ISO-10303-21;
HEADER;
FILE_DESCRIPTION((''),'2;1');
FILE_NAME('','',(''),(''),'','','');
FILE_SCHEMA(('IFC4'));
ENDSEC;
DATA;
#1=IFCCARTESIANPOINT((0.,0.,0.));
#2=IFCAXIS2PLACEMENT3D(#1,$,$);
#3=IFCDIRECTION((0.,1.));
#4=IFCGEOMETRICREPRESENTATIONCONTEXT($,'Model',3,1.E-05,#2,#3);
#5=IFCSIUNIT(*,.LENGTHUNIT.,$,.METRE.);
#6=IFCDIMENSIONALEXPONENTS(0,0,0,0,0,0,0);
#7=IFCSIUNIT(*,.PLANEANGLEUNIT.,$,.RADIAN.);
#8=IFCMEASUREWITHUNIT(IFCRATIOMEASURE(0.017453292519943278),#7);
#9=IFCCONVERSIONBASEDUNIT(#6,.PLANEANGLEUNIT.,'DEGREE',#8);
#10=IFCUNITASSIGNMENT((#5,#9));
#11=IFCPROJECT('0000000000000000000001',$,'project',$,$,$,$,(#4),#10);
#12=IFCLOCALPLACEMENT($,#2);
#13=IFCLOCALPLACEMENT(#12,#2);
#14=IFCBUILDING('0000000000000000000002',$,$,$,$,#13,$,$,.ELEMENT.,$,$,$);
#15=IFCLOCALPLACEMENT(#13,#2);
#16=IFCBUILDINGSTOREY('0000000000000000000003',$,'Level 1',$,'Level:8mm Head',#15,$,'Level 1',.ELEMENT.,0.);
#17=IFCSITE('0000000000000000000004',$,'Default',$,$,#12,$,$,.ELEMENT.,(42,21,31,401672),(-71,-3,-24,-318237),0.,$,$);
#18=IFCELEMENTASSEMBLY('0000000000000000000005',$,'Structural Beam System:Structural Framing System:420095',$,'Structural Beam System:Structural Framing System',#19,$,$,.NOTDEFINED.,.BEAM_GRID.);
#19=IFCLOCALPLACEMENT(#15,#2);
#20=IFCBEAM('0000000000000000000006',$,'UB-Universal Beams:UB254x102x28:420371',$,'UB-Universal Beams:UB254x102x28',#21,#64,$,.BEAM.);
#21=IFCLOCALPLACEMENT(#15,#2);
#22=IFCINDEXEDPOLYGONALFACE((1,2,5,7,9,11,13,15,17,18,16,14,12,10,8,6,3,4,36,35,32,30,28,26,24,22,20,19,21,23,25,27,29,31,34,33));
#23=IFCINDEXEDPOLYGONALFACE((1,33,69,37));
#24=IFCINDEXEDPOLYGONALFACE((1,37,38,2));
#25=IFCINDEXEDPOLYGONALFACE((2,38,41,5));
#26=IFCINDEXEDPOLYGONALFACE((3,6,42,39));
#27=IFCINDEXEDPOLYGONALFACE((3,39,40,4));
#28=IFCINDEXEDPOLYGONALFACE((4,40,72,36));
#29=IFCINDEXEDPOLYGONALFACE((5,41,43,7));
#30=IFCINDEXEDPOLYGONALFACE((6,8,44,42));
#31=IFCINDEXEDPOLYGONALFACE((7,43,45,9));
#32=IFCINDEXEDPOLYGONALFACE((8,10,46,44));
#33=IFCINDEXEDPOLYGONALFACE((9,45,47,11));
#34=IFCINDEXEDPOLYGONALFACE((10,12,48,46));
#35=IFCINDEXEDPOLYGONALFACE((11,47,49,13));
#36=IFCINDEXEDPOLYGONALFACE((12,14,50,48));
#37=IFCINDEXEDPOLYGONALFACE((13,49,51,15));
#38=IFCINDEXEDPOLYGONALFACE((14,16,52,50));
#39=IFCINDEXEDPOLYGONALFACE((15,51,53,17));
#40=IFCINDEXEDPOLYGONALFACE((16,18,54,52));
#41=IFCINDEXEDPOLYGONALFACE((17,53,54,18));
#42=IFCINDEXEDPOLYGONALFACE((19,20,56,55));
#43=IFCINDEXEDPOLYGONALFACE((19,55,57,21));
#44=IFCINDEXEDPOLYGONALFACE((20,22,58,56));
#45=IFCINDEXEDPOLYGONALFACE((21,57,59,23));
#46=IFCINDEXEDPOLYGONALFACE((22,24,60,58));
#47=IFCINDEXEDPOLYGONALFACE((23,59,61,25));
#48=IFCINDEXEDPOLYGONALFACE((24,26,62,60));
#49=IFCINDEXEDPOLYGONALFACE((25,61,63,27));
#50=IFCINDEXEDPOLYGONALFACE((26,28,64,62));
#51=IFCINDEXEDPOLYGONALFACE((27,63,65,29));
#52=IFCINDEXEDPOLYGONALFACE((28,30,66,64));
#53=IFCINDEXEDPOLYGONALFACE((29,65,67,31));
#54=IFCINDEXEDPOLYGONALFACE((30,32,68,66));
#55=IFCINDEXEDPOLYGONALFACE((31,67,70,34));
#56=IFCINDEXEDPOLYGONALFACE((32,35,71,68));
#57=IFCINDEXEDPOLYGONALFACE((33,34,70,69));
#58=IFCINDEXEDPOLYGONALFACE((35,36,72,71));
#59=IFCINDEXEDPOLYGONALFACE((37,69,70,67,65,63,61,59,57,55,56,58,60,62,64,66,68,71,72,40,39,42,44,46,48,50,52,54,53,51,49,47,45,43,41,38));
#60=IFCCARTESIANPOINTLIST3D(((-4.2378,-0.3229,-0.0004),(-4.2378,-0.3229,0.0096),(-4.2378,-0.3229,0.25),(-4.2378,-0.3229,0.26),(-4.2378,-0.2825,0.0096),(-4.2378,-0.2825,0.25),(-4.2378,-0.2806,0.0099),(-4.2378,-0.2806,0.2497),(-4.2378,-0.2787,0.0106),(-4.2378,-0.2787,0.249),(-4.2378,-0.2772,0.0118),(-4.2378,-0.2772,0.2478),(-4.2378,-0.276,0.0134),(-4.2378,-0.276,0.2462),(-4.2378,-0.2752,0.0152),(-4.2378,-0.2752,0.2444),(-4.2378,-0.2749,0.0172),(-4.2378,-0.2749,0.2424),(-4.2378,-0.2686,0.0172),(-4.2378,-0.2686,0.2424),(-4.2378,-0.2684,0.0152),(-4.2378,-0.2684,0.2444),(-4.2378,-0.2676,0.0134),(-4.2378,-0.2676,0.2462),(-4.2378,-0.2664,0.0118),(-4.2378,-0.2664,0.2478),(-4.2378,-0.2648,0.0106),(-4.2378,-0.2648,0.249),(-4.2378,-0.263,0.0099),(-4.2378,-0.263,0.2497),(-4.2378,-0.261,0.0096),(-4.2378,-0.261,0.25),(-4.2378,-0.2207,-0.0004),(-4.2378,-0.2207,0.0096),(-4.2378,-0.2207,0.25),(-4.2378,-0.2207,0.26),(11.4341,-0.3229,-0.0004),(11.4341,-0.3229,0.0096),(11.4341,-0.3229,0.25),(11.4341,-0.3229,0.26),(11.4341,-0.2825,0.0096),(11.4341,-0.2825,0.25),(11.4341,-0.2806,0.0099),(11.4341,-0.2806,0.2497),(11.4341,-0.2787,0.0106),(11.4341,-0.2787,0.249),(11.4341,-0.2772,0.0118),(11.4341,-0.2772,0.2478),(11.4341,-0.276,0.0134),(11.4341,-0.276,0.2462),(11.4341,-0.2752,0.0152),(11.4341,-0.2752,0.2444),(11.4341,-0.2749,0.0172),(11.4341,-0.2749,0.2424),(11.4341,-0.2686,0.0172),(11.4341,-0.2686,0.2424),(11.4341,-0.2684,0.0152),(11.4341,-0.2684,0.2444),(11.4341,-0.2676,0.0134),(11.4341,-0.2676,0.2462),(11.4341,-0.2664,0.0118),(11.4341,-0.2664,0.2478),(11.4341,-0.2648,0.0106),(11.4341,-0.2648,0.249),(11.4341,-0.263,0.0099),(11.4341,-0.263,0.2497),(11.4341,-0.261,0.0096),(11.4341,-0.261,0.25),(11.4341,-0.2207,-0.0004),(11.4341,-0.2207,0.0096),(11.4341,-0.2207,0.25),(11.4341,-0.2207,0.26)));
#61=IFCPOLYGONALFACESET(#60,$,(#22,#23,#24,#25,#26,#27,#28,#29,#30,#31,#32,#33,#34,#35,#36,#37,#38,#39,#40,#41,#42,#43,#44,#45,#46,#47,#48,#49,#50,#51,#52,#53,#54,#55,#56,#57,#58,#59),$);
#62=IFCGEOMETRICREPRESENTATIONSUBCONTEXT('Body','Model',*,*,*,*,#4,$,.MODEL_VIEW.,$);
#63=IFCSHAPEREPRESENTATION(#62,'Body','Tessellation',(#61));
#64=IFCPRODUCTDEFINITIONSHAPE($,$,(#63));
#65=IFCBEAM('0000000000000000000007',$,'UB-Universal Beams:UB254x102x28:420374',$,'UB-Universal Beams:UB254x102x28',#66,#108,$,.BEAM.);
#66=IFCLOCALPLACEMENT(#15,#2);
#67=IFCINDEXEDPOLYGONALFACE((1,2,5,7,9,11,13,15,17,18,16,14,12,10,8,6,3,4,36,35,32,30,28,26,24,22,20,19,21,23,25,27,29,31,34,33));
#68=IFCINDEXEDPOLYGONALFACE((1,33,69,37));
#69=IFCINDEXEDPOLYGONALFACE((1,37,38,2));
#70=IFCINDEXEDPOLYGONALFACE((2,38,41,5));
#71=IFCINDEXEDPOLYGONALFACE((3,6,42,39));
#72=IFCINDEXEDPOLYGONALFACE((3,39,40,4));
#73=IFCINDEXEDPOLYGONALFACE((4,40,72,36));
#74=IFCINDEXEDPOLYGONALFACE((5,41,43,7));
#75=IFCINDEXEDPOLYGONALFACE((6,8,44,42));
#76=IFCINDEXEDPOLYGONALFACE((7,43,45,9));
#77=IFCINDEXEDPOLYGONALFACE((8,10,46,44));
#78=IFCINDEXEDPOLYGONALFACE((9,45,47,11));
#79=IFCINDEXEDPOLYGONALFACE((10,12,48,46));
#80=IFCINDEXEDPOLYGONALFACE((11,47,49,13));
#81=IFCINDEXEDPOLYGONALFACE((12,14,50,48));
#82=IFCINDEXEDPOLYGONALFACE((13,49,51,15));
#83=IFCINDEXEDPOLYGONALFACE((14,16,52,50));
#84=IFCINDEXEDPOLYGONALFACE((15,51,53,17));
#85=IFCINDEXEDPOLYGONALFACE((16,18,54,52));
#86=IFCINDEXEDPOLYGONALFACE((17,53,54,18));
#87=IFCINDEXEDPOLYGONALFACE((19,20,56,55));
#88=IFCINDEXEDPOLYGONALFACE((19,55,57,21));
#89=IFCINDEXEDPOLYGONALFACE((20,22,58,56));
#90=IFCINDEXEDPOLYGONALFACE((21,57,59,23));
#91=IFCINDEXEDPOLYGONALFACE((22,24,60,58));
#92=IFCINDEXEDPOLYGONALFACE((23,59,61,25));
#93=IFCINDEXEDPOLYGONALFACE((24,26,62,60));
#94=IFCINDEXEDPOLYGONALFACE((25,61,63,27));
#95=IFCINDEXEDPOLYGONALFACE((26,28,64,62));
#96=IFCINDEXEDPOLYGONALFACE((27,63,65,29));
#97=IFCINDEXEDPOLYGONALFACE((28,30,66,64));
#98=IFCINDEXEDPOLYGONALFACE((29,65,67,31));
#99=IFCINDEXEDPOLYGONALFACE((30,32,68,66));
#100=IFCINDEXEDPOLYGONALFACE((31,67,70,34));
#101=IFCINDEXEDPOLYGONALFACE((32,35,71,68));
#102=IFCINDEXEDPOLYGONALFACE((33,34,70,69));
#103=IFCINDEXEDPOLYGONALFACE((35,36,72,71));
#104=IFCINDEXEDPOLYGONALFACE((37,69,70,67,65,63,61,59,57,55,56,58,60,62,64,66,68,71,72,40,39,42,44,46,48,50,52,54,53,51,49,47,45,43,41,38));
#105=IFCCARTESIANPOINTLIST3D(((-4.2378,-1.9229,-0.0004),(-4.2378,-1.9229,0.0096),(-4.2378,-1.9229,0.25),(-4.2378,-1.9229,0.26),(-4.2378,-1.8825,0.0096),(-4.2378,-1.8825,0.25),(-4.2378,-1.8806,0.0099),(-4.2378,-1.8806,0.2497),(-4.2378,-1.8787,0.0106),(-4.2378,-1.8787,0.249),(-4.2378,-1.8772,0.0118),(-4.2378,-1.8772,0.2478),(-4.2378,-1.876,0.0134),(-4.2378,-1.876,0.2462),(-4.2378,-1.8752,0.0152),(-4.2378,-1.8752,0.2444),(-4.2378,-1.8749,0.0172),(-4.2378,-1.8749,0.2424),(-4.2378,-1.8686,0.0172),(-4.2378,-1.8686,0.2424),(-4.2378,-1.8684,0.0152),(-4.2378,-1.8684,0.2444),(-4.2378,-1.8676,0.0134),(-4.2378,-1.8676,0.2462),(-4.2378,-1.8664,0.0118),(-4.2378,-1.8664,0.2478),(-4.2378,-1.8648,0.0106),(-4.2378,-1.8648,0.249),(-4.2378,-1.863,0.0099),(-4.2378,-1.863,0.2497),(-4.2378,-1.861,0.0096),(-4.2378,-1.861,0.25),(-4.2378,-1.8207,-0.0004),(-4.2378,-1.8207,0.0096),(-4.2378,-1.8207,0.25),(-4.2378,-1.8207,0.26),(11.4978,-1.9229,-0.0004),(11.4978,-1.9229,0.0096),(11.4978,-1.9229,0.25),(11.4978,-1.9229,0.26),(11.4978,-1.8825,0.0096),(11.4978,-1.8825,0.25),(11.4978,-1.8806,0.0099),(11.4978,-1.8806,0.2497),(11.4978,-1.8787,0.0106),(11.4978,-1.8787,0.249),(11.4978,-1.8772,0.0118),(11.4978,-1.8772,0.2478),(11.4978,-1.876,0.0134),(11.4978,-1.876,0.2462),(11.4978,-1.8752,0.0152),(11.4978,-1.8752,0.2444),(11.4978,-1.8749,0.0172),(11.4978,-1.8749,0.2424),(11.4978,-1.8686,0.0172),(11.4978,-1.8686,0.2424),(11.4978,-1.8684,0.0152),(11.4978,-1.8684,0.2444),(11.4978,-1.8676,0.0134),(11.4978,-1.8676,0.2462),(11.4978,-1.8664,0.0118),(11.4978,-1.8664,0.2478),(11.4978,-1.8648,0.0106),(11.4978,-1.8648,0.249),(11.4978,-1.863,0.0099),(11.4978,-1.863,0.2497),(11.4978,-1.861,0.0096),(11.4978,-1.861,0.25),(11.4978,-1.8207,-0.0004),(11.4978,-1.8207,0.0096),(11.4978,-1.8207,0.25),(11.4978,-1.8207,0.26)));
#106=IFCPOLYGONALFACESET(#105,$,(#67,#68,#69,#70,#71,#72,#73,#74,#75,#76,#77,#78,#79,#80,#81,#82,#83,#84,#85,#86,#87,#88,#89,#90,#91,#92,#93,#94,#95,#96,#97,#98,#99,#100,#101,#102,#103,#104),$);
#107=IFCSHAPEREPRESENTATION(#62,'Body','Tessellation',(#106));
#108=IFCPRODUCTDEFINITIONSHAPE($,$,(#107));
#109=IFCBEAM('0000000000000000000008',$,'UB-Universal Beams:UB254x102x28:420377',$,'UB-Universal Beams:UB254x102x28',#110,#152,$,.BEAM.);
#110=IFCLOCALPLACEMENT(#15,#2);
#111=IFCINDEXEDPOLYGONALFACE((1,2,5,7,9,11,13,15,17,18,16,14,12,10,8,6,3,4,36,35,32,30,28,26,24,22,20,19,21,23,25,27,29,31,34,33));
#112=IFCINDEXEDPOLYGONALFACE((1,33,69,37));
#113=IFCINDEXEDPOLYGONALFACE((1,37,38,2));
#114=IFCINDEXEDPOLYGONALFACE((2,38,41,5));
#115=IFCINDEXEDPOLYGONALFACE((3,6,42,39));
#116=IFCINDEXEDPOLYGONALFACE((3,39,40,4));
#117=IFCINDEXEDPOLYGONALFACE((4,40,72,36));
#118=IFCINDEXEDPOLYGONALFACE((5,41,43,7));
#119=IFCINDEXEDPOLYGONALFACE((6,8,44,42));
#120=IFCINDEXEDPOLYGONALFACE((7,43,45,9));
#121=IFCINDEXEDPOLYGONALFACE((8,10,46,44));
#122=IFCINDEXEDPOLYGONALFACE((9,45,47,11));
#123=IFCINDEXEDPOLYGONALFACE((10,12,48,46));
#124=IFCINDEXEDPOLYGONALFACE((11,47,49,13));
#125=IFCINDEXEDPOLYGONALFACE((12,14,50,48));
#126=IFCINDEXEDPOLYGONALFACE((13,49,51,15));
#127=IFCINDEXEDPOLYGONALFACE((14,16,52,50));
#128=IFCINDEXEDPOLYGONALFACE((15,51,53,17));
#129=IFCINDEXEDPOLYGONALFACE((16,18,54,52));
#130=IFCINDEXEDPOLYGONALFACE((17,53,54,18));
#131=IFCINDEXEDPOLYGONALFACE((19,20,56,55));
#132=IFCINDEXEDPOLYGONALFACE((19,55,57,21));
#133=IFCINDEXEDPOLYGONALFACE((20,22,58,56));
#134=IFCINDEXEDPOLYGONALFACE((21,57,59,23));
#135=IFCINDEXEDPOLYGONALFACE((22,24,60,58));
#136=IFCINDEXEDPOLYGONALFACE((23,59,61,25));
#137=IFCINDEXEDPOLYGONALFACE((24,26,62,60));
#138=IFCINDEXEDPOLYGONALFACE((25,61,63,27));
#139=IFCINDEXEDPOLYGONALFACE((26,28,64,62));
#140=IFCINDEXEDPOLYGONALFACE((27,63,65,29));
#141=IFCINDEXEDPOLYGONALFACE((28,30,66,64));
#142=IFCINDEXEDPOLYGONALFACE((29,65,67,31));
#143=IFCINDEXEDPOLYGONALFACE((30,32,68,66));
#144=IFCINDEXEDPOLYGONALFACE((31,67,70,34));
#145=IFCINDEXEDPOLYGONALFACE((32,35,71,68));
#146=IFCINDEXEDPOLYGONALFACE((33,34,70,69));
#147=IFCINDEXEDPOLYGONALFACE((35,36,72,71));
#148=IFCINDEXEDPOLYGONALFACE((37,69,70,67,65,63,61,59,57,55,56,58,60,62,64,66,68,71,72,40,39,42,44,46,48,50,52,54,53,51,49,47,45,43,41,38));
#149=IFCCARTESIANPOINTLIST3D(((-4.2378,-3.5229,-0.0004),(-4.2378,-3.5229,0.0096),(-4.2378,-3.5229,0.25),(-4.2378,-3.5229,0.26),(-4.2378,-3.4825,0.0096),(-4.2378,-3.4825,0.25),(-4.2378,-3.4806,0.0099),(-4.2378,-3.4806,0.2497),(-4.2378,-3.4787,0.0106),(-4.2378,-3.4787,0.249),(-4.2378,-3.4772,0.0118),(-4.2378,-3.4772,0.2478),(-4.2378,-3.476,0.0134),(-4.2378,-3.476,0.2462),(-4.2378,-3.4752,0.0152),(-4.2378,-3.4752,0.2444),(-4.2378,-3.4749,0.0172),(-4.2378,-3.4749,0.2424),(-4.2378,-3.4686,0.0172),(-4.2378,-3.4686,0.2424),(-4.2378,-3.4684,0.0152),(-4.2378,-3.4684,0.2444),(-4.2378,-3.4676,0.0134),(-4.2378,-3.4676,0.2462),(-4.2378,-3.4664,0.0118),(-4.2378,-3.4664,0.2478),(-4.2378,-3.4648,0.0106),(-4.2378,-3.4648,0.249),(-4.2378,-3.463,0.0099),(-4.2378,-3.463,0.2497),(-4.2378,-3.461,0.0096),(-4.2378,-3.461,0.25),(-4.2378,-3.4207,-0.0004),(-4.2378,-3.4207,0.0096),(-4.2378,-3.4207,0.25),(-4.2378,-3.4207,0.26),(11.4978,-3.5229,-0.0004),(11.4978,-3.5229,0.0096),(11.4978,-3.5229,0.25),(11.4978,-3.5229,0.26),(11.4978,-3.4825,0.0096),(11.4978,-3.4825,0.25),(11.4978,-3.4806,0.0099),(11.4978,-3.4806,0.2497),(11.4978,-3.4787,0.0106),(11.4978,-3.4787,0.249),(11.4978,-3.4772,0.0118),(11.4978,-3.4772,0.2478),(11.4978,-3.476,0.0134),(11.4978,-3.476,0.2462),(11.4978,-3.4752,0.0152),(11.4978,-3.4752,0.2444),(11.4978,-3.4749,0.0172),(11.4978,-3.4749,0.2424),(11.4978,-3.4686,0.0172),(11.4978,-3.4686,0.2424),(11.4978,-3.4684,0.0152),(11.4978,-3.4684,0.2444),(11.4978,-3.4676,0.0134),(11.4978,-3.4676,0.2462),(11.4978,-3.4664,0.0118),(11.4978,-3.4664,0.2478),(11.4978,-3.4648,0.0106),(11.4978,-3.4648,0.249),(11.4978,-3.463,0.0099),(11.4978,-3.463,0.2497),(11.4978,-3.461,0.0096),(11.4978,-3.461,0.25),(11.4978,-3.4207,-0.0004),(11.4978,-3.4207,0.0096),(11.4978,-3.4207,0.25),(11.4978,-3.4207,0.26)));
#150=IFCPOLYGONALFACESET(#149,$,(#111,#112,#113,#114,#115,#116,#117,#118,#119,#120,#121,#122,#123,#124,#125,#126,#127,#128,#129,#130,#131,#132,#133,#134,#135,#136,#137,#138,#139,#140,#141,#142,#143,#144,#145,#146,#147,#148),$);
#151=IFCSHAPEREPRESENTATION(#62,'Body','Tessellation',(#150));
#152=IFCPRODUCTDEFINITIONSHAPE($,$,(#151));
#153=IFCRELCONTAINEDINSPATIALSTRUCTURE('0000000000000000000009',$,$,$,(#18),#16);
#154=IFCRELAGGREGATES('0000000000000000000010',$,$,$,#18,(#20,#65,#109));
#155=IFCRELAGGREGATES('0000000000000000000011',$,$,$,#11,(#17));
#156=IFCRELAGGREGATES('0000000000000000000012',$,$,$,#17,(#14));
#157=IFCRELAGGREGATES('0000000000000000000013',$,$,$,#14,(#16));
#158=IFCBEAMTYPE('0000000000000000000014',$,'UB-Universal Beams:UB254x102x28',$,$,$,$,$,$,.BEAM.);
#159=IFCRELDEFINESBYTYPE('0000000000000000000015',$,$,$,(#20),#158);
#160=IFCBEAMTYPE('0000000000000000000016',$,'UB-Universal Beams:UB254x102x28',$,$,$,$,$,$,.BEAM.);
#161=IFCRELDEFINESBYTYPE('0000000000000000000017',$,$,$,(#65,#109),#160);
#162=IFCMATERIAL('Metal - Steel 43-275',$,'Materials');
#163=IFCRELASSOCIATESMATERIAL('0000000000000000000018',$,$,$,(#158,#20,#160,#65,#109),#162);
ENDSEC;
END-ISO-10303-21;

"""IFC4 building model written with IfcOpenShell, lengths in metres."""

from ifc_helpers import new_model, entity, si_unit, converted_unit, direction, frame, origin, place, context, subcontext, project, spatial, line, arc, indexed_curve, outline, extrude, source, transform, mapped, material, type_object, type_shapes, element, aggregate, save


model = new_model("IFC4")

# Units and contexts
model_context = context("Model", 3, precision=1e-05, world=origin(), true_north=direction((0.0, 1.0)))
body_context = subcontext(model_context, "Body", "Model", "MODEL_VIEW")
ifc_project = project(units=[si_unit("LENGTHUNIT", "METRE"), converted_unit("PLANEANGLEUNIT", "DEGREE", entity("IfcRatioMeasure", 0.017453292519943278), si_unit("PLANEANGLEUNIT", "RADIAN"), dimensions=[0, 0, 0, 0, 0, 0, 0])], contexts=[model_context])

# Site, building, storey
site_placement = place(None, origin())
site = spatial("IfcSite", under=ifc_project, at=site_placement, Name="Default", CompositionType="ELEMENT", RefLatitude=(42, 21, 31, 401672), RefLongitude=(-71, -3, -24, -318237), RefElevation=0.0)
building_placement = place(site_placement, origin())
building = spatial("IfcBuilding", under=site, at=building_placement, CompositionType="ELEMENT")
storey_placement = place(building_placement, origin())
storey = spatial("IfcBuildingStorey", under=building, at=storey_placement, Name="Level 1", ObjectType="Level:8mm Head", LongName="Level 1", CompositionType="ELEMENT", Elevation=0.0)

# Shared definitions
ifc_material_1 = material(Name="Metal - Steel 43-275", Category="Materials")

# Element assembly, beams
assembly_placement = place(storey_placement, origin())
assembly = element("IfcElementAssembly", 1, at=assembly_placement, inside=storey, Name="Structural Beam System:Structural Framing System:420095", ObjectType="Structural Beam System:Structural Framing System", AssemblyPlace="NOTDEFINED", PredefinedType="BEAM_GRID")
beam_type_1 = type_object("IfcBeamType", Name="UB-Universal Beams:UB254x102x28", PredefinedType="BEAM", material=ifc_material_1)
shared_shape_1 = source(origin(), body_context, "Body", "SweptSolid", [
    extrude(outline(indexed_curve([(-0.1302, -0.0511), (-0.1202, -0.0511), (-0.1202, -0.0107), (-0.118, -0.0054), (-0.1126, -0.0031), (0.1126, -0.0031), (0.118, -0.0054), (0.1202, -0.0107), (0.1202, -0.0511), (0.1302, -0.0511), (0.1302, 0.0511), (0.1202, 0.0511), (0.1202, 0.0108), (0.118, 0.0054), (0.1126, 0.0032), (-0.1126, 0.0032), (-0.118, 0.0054), (-0.1202, 0.0108), (-0.1202, 0.0511), (-0.1302, 0.0511)], segments=[line(1, 2, 3), arc(3, 4, 5), line(5, 6), arc(6, 7, 8), line(8, 9, 10, 11, 12, 13), arc(13, 14, 15), line(15, 16), arc(16, 17, 18), line(18, 19, 20, 1)], self_intersect=False)), frame((-7.8818, 0.0, 0.0), z_axis=(1.0, 0.0, 0.0), x_axis=(0.0, 0.0, -1.0)), (0.0, 0.0, 1.0), 15.6719),
])
type_shapes(beam_type_1, [shared_shape_1])
beam_1_placement = place(assembly_placement, frame((3.644, -0.2718, 0.1298)))
beam_1 = element("IfcBeam", 2, at=beam_1_placement, type_object=beam_type_1, material=ifc_material_1, Name="UB-Universal Beams:UB254x102x28:420371", ObjectType="UB-Universal Beams:UB254x102x28", PredefinedType="BEAM", context=body_context, shape_type="MappedRepresentation", body=[
    mapped(shared_shape_1, transform((0.0, 0.0, 0.0), scale=1.0)),
])
beam_type_2 = type_object("IfcBeamType", Name="UB-Universal Beams:UB254x102x28", PredefinedType="BEAM", material=ifc_material_1)
shared_shape_2 = source(origin(), body_context, "Body", "SweptSolid", [
    extrude(outline(indexed_curve([(-0.1302, -0.0511), (-0.1202, -0.0511), (-0.1202, -0.0107), (-0.118, -0.0054), (-0.1126, -0.0031), (0.1126, -0.0031), (0.118, -0.0054), (0.1202, -0.0107), (0.1202, -0.0511), (0.1302, -0.0511), (0.1302, 0.0511), (0.1202, 0.0511), (0.1202, 0.0108), (0.118, 0.0054), (0.1126, 0.0032), (-0.1126, 0.0032), (-0.118, 0.0054), (-0.1202, 0.0108), (-0.1202, 0.0511), (-0.1302, 0.0511)], segments=[line(1, 2, 3), arc(3, 4, 5), line(5, 6), arc(6, 7, 8), line(8, 9, 10, 11, 12, 13), arc(13, 14, 15), line(15, 16), arc(16, 17, 18), line(18, 19, 20, 1)], self_intersect=False)), frame((-7.8373, 0.0, 0.0), z_axis=(1.0, 0.0, 0.0), x_axis=(0.0, 0.0, -1.0)), (0.0, 0.0, 1.0), 15.7356),
])
type_shapes(beam_type_2, [shared_shape_2])
beam_2_placement = place(assembly_placement, frame((3.5995, -1.8718, 0.1298)))
beam_2 = element("IfcBeam", 3, at=beam_2_placement, type_object=beam_type_2, material=ifc_material_1, Name="UB-Universal Beams:UB254x102x28:420374", ObjectType="UB-Universal Beams:UB254x102x28", PredefinedType="BEAM", context=body_context, shape_type="MappedRepresentation", body=[
    mapped(shared_shape_2, transform((0.0, 0.0, 0.0), scale=1.0)),
])
beam_3_placement = place(assembly_placement, frame((3.5995, -3.4718, 0.1298)))
beam_3 = element("IfcBeam", 4, at=beam_3_placement, type_object=beam_type_2, material=ifc_material_1, Name="UB-Universal Beams:UB254x102x28:420377", ObjectType="UB-Universal Beams:UB254x102x28", PredefinedType="BEAM", context=body_context, shape_type="MappedRepresentation", body=[
    mapped(shared_shape_2, transform((0.0, 0.0, 0.0), scale=1.0)),
])
aggregate(assembly, [beam_1, beam_2, beam_3])

save(model, "model.ifc")
